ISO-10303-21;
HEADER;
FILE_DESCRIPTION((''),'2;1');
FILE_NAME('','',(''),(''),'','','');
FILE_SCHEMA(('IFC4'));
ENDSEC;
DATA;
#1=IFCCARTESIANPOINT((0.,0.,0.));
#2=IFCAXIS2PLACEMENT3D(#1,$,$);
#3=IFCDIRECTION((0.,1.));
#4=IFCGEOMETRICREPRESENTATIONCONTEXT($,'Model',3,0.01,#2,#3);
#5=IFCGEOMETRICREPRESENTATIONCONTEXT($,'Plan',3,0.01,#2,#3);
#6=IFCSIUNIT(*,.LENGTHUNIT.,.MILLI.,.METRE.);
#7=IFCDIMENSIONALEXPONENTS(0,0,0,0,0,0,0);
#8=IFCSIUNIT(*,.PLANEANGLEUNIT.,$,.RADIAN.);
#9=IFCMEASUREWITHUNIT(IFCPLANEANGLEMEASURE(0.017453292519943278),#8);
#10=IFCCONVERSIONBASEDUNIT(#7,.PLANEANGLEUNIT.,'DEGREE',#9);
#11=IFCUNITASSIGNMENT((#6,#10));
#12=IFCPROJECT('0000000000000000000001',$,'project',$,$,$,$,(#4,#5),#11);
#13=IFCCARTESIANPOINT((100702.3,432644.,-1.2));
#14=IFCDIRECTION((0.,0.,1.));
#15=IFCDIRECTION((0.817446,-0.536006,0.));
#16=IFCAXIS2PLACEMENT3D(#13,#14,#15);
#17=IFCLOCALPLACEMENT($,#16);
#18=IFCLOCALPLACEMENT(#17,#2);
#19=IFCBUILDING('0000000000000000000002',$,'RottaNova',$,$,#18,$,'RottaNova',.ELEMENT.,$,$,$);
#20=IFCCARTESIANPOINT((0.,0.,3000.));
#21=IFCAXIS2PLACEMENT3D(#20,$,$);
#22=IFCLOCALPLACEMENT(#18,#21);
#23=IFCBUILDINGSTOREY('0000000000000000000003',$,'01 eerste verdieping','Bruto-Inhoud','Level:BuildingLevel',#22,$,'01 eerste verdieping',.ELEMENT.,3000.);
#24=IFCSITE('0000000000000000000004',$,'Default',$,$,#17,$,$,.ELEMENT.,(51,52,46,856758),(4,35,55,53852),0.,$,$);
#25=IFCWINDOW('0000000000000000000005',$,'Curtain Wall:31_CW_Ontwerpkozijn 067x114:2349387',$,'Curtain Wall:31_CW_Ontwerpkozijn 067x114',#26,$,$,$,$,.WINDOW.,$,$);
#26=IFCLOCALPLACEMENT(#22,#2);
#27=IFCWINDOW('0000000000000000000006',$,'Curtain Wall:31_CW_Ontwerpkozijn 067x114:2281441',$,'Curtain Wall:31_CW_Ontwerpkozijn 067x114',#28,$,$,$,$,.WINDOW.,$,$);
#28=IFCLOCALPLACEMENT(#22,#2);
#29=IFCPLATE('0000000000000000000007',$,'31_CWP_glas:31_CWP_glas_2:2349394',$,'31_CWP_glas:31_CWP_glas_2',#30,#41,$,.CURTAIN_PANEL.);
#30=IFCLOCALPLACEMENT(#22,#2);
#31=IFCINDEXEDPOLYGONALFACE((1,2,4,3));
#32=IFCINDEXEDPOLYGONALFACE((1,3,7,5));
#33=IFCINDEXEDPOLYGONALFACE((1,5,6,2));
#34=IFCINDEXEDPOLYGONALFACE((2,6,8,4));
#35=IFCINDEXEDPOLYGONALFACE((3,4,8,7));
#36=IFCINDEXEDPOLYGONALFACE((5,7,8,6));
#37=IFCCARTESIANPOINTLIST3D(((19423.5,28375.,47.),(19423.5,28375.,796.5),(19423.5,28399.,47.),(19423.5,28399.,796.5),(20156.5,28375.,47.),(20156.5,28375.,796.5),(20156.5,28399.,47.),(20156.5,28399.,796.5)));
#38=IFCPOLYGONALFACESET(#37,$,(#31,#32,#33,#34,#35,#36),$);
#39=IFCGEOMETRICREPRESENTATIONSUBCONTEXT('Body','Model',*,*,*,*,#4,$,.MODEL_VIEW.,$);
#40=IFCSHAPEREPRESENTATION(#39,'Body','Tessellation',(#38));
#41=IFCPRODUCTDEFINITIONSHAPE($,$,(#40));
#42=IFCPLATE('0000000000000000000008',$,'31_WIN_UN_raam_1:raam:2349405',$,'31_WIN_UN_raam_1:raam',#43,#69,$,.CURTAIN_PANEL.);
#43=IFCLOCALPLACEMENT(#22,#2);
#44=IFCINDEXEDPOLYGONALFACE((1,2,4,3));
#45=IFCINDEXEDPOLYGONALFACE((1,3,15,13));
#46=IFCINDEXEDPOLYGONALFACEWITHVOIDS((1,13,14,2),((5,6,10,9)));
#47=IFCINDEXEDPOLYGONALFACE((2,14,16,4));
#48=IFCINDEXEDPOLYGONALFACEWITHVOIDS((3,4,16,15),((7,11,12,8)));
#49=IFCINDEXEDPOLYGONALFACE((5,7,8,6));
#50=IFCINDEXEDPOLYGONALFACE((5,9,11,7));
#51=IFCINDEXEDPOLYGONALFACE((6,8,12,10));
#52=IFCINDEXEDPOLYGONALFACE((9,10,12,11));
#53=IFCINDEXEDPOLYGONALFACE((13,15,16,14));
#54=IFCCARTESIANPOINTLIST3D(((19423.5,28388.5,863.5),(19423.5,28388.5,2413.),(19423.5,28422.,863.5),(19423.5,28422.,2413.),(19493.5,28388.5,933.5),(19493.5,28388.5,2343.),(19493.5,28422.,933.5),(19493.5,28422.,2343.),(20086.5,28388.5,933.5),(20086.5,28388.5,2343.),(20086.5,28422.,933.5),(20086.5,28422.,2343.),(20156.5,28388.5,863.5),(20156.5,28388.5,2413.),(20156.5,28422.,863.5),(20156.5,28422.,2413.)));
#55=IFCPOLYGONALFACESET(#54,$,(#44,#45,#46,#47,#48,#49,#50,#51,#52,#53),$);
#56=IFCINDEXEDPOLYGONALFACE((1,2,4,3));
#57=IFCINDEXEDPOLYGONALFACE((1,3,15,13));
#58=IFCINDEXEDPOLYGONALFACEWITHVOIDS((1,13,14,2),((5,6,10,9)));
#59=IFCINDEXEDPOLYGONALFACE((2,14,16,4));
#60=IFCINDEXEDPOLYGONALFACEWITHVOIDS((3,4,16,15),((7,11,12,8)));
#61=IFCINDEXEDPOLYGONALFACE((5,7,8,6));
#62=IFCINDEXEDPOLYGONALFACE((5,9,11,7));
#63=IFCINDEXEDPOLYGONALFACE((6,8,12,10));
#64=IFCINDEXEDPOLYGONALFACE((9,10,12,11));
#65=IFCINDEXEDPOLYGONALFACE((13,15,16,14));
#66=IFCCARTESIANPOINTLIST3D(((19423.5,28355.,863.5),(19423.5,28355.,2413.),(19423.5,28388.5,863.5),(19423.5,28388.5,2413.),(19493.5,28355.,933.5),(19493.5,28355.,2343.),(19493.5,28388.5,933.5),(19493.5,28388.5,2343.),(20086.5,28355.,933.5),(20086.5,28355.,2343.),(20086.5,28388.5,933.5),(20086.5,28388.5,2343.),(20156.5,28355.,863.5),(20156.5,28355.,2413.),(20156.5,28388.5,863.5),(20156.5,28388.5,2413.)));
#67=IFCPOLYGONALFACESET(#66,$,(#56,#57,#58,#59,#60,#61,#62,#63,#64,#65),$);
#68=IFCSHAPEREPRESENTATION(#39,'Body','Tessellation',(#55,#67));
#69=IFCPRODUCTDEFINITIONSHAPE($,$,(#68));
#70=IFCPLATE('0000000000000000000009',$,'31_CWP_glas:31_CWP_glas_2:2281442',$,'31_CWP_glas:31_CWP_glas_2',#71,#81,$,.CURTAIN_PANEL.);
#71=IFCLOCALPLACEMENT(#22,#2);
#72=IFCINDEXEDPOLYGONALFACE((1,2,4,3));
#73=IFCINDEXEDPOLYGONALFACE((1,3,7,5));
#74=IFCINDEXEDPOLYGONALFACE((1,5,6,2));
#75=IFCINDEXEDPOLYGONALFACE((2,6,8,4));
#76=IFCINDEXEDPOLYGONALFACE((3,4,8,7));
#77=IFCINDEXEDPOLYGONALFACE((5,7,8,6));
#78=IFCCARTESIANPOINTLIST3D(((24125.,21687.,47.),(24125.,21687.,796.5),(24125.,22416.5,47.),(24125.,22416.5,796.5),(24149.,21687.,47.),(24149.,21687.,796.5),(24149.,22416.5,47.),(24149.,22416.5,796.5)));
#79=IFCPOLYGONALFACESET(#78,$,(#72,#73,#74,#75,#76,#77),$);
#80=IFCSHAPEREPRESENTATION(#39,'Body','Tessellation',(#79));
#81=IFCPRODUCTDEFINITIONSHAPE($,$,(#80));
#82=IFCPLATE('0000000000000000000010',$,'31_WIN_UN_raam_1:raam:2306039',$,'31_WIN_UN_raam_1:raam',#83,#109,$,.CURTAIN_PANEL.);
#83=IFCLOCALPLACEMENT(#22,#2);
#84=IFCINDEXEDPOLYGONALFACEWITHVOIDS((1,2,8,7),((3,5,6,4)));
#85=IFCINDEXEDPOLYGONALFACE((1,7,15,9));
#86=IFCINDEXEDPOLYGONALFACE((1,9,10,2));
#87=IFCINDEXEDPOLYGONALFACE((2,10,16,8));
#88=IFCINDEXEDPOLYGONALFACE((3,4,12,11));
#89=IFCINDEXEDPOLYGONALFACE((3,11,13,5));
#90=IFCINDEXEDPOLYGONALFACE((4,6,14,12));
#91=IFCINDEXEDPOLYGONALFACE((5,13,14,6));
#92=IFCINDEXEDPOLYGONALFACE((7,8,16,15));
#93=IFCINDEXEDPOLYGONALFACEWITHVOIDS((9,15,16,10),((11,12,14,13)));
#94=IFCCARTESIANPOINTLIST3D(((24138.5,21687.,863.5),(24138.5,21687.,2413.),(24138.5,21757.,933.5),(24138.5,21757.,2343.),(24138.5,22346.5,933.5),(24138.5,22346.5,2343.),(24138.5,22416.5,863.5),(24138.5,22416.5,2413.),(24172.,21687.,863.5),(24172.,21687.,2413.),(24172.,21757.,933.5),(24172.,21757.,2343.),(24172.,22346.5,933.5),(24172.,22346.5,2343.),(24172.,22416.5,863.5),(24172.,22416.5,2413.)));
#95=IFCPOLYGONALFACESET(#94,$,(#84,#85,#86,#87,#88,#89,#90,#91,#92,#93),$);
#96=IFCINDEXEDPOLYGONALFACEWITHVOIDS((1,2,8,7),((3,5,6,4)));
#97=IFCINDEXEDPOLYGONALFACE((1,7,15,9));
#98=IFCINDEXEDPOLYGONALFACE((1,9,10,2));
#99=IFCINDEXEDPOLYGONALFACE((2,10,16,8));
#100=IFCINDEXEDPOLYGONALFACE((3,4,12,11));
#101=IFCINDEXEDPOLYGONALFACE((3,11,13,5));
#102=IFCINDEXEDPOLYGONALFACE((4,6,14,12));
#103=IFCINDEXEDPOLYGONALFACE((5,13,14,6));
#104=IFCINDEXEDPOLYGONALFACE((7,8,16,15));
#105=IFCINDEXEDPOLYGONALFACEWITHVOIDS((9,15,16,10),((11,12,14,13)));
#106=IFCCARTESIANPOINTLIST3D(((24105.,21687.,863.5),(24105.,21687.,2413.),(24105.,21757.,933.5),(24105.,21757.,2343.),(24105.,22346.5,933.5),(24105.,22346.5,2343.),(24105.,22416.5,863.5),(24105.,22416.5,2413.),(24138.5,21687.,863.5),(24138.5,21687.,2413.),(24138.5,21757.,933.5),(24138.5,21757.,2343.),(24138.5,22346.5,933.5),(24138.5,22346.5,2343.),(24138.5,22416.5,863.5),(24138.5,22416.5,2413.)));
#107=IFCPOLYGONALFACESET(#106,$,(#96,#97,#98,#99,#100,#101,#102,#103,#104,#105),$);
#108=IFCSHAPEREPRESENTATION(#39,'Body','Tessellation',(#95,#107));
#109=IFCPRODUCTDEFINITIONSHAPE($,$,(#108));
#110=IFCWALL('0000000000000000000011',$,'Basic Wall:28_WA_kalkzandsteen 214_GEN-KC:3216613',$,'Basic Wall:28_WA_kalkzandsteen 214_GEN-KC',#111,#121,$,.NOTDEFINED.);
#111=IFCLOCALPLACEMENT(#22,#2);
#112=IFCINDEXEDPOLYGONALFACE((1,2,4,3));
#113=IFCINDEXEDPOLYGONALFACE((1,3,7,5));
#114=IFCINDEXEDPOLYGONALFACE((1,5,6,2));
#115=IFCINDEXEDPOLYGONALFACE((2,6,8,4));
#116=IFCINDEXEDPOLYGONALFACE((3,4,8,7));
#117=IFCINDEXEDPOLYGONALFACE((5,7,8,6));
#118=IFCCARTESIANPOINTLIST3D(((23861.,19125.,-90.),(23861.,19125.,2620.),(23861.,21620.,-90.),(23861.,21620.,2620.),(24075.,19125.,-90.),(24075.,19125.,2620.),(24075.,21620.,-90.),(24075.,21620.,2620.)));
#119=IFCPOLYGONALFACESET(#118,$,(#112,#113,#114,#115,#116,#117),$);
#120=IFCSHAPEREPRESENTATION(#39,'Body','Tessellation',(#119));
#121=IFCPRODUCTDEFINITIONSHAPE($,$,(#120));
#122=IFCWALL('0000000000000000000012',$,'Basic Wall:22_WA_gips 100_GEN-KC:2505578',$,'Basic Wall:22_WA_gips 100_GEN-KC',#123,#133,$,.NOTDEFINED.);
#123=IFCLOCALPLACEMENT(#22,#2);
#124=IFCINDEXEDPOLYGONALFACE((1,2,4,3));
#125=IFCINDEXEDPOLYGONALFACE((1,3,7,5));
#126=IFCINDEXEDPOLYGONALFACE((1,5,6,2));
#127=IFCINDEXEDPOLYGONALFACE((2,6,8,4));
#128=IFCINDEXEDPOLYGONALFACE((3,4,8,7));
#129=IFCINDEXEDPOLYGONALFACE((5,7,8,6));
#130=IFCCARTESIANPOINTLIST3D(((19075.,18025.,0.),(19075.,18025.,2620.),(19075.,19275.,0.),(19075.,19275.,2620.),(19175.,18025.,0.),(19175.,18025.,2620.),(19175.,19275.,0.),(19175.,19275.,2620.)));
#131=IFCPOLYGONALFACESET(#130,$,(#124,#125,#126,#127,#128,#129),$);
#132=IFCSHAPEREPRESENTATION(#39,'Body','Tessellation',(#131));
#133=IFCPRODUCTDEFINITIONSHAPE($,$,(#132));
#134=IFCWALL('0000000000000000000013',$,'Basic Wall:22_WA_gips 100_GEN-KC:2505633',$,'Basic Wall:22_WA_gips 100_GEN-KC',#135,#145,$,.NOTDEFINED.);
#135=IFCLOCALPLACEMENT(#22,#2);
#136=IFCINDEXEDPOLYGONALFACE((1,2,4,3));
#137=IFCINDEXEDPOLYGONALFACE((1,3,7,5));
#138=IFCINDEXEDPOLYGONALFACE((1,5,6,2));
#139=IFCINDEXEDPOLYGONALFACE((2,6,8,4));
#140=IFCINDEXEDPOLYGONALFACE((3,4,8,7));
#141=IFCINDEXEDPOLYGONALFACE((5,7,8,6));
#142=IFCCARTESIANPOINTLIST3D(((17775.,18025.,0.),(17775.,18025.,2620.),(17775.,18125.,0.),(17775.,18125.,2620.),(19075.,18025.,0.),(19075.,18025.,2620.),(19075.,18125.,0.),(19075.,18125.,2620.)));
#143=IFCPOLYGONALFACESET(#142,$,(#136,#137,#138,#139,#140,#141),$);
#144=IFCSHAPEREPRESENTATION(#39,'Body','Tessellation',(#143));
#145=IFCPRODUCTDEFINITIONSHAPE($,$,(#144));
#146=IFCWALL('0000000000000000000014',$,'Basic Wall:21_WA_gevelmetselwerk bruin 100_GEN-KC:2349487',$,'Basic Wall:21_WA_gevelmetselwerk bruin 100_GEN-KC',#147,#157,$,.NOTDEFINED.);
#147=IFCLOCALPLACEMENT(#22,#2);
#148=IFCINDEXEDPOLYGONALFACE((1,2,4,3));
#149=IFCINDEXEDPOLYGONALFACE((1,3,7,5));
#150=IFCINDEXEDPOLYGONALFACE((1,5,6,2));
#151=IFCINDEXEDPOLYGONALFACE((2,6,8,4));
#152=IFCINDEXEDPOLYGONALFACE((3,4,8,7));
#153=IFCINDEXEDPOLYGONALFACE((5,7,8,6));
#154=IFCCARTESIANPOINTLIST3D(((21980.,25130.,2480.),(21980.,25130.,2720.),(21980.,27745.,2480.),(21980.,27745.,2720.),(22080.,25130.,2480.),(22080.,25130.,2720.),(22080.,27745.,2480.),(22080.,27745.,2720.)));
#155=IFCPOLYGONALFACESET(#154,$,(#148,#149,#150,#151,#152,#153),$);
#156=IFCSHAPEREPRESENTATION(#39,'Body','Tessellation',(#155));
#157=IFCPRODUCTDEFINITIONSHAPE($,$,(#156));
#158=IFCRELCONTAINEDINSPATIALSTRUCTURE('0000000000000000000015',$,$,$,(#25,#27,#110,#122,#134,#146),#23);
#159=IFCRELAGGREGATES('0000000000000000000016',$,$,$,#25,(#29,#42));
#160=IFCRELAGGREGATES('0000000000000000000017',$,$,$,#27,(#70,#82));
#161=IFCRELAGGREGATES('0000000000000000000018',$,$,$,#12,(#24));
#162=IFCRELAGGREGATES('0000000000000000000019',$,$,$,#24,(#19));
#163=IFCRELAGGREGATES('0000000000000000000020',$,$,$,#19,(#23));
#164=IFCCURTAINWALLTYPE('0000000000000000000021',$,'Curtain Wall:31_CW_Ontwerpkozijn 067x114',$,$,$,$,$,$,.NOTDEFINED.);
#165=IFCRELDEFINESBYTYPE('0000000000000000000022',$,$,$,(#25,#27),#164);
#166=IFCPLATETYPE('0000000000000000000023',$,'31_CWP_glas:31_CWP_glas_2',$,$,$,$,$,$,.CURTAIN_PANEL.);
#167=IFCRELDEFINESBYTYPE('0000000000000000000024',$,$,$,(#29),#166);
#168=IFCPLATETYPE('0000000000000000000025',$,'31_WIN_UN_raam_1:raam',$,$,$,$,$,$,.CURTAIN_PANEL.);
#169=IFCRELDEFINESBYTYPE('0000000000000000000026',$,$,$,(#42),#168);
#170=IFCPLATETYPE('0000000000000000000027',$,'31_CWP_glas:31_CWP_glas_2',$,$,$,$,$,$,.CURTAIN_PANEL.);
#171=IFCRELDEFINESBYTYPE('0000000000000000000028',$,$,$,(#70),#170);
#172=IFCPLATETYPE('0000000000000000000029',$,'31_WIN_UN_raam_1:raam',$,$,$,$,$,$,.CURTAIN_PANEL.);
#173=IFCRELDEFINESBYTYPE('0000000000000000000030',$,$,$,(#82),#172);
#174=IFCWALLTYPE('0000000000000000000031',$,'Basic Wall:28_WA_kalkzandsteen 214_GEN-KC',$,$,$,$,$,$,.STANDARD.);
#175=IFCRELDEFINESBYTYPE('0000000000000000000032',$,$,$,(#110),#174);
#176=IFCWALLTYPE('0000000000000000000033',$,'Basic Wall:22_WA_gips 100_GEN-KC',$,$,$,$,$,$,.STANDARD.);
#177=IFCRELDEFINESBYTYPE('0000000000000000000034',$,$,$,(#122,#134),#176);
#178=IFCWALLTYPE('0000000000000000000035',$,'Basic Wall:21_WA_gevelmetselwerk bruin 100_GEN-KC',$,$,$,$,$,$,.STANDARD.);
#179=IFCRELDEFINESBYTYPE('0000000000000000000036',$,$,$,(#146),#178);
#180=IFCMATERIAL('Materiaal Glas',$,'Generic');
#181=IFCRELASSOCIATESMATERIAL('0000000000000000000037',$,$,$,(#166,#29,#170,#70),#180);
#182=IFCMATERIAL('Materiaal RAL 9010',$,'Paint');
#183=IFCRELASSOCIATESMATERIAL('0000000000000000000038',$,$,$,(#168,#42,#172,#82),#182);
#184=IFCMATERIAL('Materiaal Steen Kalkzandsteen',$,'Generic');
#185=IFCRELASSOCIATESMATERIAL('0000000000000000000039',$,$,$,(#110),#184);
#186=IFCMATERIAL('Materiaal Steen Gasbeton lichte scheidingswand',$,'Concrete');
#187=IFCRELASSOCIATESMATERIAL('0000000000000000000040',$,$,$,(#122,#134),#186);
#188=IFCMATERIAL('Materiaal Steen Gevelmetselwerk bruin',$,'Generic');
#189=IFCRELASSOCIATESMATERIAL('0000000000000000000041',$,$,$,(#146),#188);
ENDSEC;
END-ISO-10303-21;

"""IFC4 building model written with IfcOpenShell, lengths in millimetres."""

from ifc_helpers import new_model, entity, si_unit, converted_unit, direction, frame, origin, place, context, subcontext, project, spatial, indexed_curve, outline, extrude, source, transform, mapped, material, type_object, type_shapes, element, aggregate, save


model = new_model("IFC4")

# Units and contexts
model_context = context("Model", 3, precision=0.01, world=origin(), true_north=direction((0.0, 1.0)))
plan_context = context("Plan", 3, precision=0.01, world=origin(), true_north=direction((0.0, 1.0)))
body_context = subcontext(model_context, "Body", "Model", "MODEL_VIEW")
ifc_project = project(units=[si_unit("LENGTHUNIT", "METRE", prefix="MILLI"), converted_unit("PLANEANGLEUNIT", "DEGREE", entity("IfcPlaneAngleMeasure", 0.017453292519943278), si_unit("PLANEANGLEUNIT", "RADIAN"), dimensions=[0, 0, 0, 0, 0, 0, 0])], contexts=[model_context, plan_context])

# Site, building, storey
site_placement = place(None, frame((100702.3, 432644.0, -1.2), z_axis=(0.0, 0.0, 1.0), x_axis=(0.817446, -0.536006, 0.0)))
site = spatial("IfcSite", under=ifc_project, at=site_placement, Name="Default", CompositionType="ELEMENT", RefLatitude=(51, 52, 46, 856758), RefLongitude=(4, 35, 55, 53852), RefElevation=0.0)
building_placement = place(site_placement, origin())
building = spatial("IfcBuilding", under=site, at=building_placement, Name="RottaNova", LongName="RottaNova", CompositionType="ELEMENT")
storey_placement = place(building_placement, frame((0.0, 0.0, 3000.0)))
storey = spatial("IfcBuildingStorey", under=building, at=storey_placement, Name="01 eerste verdieping", Description="Bruto-Inhoud", ObjectType="Level:BuildingLevel", LongName="01 eerste verdieping", CompositionType="ELEMENT", Elevation=3000.0)

# Shared definitions
curtain_wall_type = type_object("IfcCurtainWallType", Name="Curtain Wall:31_CW_Ontwerpkozijn 067x114", PredefinedType="NOTDEFINED")

# Window
window_1_placement = place(storey_placement, frame((0.0, 0.0, -3000.0)))
window_1 = element("IfcWindow", 1, at=window_1_placement, inside=storey, type_object=curtain_wall_type, Name="Curtain Wall:31_CW_Ontwerpkozijn 067x114:2349387", ObjectType="Curtain Wall:31_CW_Ontwerpkozijn 067x114", PredefinedType="WINDOW")

# Window
window_2_placement = place(storey_placement, frame((0.0, 0.0, -3000.0)))
window_2 = element("IfcWindow", 2, at=window_2_placement, inside=storey, type_object=curtain_wall_type, Name="Curtain Wall:31_CW_Ontwerpkozijn 067x114:2281441", ObjectType="Curtain Wall:31_CW_Ontwerpkozijn 067x114", PredefinedType="WINDOW")

# Plates
ifc_material_1 = material(Name="Materiaal Glas", Category="Generic")
plate_type_1 = type_object("IfcPlateType", Name="31_CWP_glas:31_CWP_glas_2", PredefinedType="CURTAIN_PANEL", material=ifc_material_1)
shared_shape_1 = source(origin(), body_context, "Body", "SweptSolid", [
    extrude(outline(indexed_curve([(-12.0, -366.5), (12.0, -366.5), (12.0, 366.5), (-12.0, 366.5), (-12.0, -366.5)], self_intersect=False)), frame((0.0, 57.0, 0.0), z_axis=(0.0, 0.0, 1.0), x_axis=(0.0, 1.0, 0.0)), (0.0, 0.0, 1.0), 749.5),
])
type_shapes(plate_type_1, [shared_shape_1])
plate_1_placement = place(window_1_placement, frame((19790.0, 28330.0, 3047.0)))
plate_1 = element("IfcPlate", 3, at=plate_1_placement, type_object=plate_type_1, material=ifc_material_1, Name="31_CWP_glas:31_CWP_glas_2:2349394", ObjectType="31_CWP_glas:31_CWP_glas_2", PredefinedType="CURTAIN_PANEL", context=body_context, shape_type="MappedRepresentation", body=[
    mapped(shared_shape_1, transform((0.0, 0.0, 0.0), scale=1.0)),
])
ifc_material_2 = material(Name="Materiaal RAL 9010", Category="Paint")
plate_type_2 = type_object("IfcPlateType", Name="31_WIN_UN_raam_1:raam", PredefinedType="CURTAIN_PANEL", material=ifc_material_2)
shared_shape_2 = source(origin(), body_context, "Body", "SweptSolid", [
    extrude(outline(indexed_curve([(-366.5, -774.8), (366.5, -774.8), (366.5, 774.8), (-366.5, 774.8), (-366.5, -774.8)], self_intersect=False), holes=[indexed_curve([(-296.5, 704.8), (296.5, 704.8), (296.5, -704.8), (-296.5, -704.8), (-296.5, 704.8)], self_intersect=False)]), frame((0.0, 58.5, 774.8), z_axis=(0.0, 1.0, 0.0), x_axis=(1.0, 0.0, 0.0)), (0.0, 0.0, 1.0), 33.5),
    extrude(outline(indexed_curve([(-366.5, -774.8), (366.5, -774.8), (366.5, 774.8), (-366.5, 774.8), (-366.5, -774.8)], self_intersect=False), holes=[indexed_curve([(-296.5, 704.7), (296.5, 704.7), (296.5, -704.8), (-296.5, -704.8), (-296.5, 704.7)], self_intersect=False)]), frame((0.0, 25.0, 774.8), z_axis=(0.0, 1.0, 0.0), x_axis=(1.0, 0.0, 0.0)), (0.0, 0.0, 1.0), 33.5),
])
type_shapes(plate_type_2, [shared_shape_2])
plate_2_placement = place(window_1_placement, frame((19790.0, 28330.0, 3863.5)))
plate_2 = element("IfcPlate", 4, at=plate_2_placement, type_object=plate_type_2, material=ifc_material_2, Name="31_WIN_UN_raam_1:raam:2349405", ObjectType="31_WIN_UN_raam_1:raam", PredefinedType="CURTAIN_PANEL", context=body_context, shape_type="MappedRepresentation", body=[
    mapped(shared_shape_2, transform((0.0, 0.0, 0.0), scale=1.0)),
])
aggregate(window_1, [plate_1, plate_2])
plate_type_3 = type_object("IfcPlateType", Name="31_CWP_glas:31_CWP_glas_2", PredefinedType="CURTAIN_PANEL", material=ifc_material_1)
shared_shape_3 = source(origin(), body_context, "Body", "SweptSolid", [
    extrude(outline(indexed_curve([(-12.0, -364.7), (12.0, -364.7), (12.0, 364.7), (-12.0, 364.7), (-12.0, -364.7)], self_intersect=False)), frame((0.0, -57.0, 0.0), z_axis=(0.0, 0.0, 1.0), x_axis=(0.0, 1.0, 0.0)), (0.0, 0.0, 1.0), 749.5),
])
type_shapes(plate_type_3, [shared_shape_3])
plate_3_placement = place(window_2_placement, frame((24080.0, 22051.7, 3047.0), z_axis=(0.0, 0.0, 1.0), x_axis=(0.0, 1.0, 0.0)))
plate_3 = element("IfcPlate", 5, at=plate_3_placement, type_object=plate_type_3, material=ifc_material_1, Name="31_CWP_glas:31_CWP_glas_2:2281442", ObjectType="31_CWP_glas:31_CWP_glas_2", PredefinedType="CURTAIN_PANEL", context=body_context, shape_type="MappedRepresentation", body=[
    mapped(shared_shape_3, transform((0.0, 0.0, 0.0), scale=1.0)),
])
plate_type_4 = type_object("IfcPlateType", Name="31_WIN_UN_raam_1:raam", PredefinedType="CURTAIN_PANEL", material=ifc_material_2)
shared_shape_4 = source(origin(), body_context, "Body", "SweptSolid", [
    extrude(outline(indexed_curve([(-364.7, -774.7), (364.7, -774.7), (364.7, 774.7), (-364.7, 774.7), (-364.7, -774.7)], self_intersect=False), holes=[indexed_curve([(-294.7, 704.7), (294.7, 704.7), (294.7, -704.8), (-294.7, -704.8), (-294.7, 704.7)], self_intersect=False)]), frame((0.0, -92.0, 774.8), z_axis=(0.0, 1.0, 0.0), x_axis=(1.0, 0.0, 0.0)), (0.0, 0.0, 1.0), 33.5),
    extrude(outline(indexed_curve([(-364.7, -774.7), (364.7, -774.7), (364.7, 774.7), (-364.7, 774.7), (-364.7, -774.7)], self_intersect=False), holes=[indexed_curve([(-294.7, 704.7), (294.7, 704.7), (294.7, -704.8), (-294.7, -704.8), (-294.7, 704.7)], self_intersect=False)]), frame((0.0, -58.5, 774.8), z_axis=(0.0, 1.0, 0.0), x_axis=(1.0, 0.0, 0.0)), (0.0, 0.0, 1.0), 33.5),
])
type_shapes(plate_type_4, [shared_shape_4])
plate_4_placement = place(window_2_placement, frame((24080.0, 22051.7, 3863.5), z_axis=(0.0, 0.0, 1.0), x_axis=(0.0, 1.0, 0.0)))
plate_4 = element("IfcPlate", 6, at=plate_4_placement, type_object=plate_type_4, material=ifc_material_2, Name="31_WIN_UN_raam_1:raam:2306039", ObjectType="31_WIN_UN_raam_1:raam", PredefinedType="CURTAIN_PANEL", context=body_context, shape_type="MappedRepresentation", body=[
    mapped(shared_shape_4, transform((0.0, 0.0, 0.0), scale=1.0)),
])
aggregate(window_2, [plate_3, plate_4])

# Walls
ifc_material_3 = material(Name="Materiaal Steen Kalkzandsteen", Category="Generic")
wall_type_1 = type_object("IfcWallType", Name="Basic Wall:28_WA_kalkzandsteen 214_GEN-KC", PredefinedType="STANDARD")
wall_1_placement = place(storey_placement, frame((23968.0, 21620.0, -90.0), z_axis=(0.0, 0.0, 1.0), x_axis=(0.0, -1.0, 0.0)))
element("IfcWall", 7, at=wall_1_placement, inside=storey, type_object=wall_type_1, material=ifc_material_3, Name="Basic Wall:28_WA_kalkzandsteen 214_GEN-KC:3216613", ObjectType="Basic Wall:28_WA_kalkzandsteen 214_GEN-KC", PredefinedType="NOTDEFINED", context=body_context, shape_type="SweptSolid", body=[
    extrude(outline(indexed_curve([(2495.0, 107.0), (0.0, 107.0), (0.0, -107.0), (2495.0, -107.0), (2495.0, 107.0)], self_intersect=False)), origin(), (0.0, 0.0, 1.0), 2710.0),
])
ifc_material_4 = material(Name="Materiaal Steen Gasbeton lichte scheidingswand", Category="Concrete")
wall_type_2 = type_object("IfcWallType", Name="Basic Wall:22_WA_gips 100_GEN-KC", PredefinedType="STANDARD")
wall_2_placement = place(storey_placement, frame((19125.0, 19275.0, 0.0), z_axis=(0.0, 0.0, 1.0), x_axis=(0.0, -1.0, 0.0)))
element("IfcWall", 8, at=wall_2_placement, inside=storey, type_object=wall_type_2, material=ifc_material_4, Name="Basic Wall:22_WA_gips 100_GEN-KC:2505578", ObjectType="Basic Wall:22_WA_gips 100_GEN-KC", PredefinedType="NOTDEFINED", context=body_context, shape_type="SweptSolid", body=[
    extrude(outline(indexed_curve([(1250.0, 50.0), (0.0, 50.0), (0.0, -50.0), (1250.0, -50.0), (1250.0, 50.0)], self_intersect=False)), origin(), (0.0, 0.0, 1.0), 2620.0),
])
wall_3_placement = place(storey_placement, frame((19075.0, 18075.0, 0.0), z_axis=(0.0, 0.0, 1.0), x_axis=(-1.0, 0.0, 0.0)))
element("IfcWall", 9, at=wall_3_placement, inside=storey, type_object=wall_type_2, material=ifc_material_4, Name="Basic Wall:22_WA_gips 100_GEN-KC:2505633", ObjectType="Basic Wall:22_WA_gips 100_GEN-KC", PredefinedType="NOTDEFINED", context=body_context, shape_type="SweptSolid", body=[
    extrude(outline(indexed_curve([(1300.0, 50.0), (0.0, 50.0), (0.0, -50.0), (1300.0, -50.0), (1300.0, 50.0)], self_intersect=False)), origin(), (0.0, 0.0, 1.0), 2620.0),
])
ifc_material_5 = material(Name="Materiaal Steen Gevelmetselwerk bruin", Category="Generic")
wall_type_3 = type_object("IfcWallType", Name="Basic Wall:21_WA_gevelmetselwerk bruin 100_GEN-KC", PredefinedType="STANDARD")
wall_4_placement = place(storey_placement, frame((22030.0, 25130.0, 2480.0), z_axis=(0.0, 0.0, 1.0), x_axis=(0.0, 1.0, 0.0)))
element("IfcWall", 10, at=wall_4_placement, inside=storey, type_object=wall_type_3, material=ifc_material_5, Name="Basic Wall:21_WA_gevelmetselwerk bruin 100_GEN-KC:2349487", ObjectType="Basic Wall:21_WA_gevelmetselwerk bruin 100_GEN-KC", PredefinedType="NOTDEFINED", context=body_context, shape_type="SweptSolid", body=[
    extrude(outline(indexed_curve([(2615.0, 50.0), (0.0, 50.0), (0.0, -50.0), (2615.0, -50.0), (2615.0, 50.0)], self_intersect=False)), origin(), (0.0, 0.0, 1.0), 240.0),
])

save(model, "model.ifc")
